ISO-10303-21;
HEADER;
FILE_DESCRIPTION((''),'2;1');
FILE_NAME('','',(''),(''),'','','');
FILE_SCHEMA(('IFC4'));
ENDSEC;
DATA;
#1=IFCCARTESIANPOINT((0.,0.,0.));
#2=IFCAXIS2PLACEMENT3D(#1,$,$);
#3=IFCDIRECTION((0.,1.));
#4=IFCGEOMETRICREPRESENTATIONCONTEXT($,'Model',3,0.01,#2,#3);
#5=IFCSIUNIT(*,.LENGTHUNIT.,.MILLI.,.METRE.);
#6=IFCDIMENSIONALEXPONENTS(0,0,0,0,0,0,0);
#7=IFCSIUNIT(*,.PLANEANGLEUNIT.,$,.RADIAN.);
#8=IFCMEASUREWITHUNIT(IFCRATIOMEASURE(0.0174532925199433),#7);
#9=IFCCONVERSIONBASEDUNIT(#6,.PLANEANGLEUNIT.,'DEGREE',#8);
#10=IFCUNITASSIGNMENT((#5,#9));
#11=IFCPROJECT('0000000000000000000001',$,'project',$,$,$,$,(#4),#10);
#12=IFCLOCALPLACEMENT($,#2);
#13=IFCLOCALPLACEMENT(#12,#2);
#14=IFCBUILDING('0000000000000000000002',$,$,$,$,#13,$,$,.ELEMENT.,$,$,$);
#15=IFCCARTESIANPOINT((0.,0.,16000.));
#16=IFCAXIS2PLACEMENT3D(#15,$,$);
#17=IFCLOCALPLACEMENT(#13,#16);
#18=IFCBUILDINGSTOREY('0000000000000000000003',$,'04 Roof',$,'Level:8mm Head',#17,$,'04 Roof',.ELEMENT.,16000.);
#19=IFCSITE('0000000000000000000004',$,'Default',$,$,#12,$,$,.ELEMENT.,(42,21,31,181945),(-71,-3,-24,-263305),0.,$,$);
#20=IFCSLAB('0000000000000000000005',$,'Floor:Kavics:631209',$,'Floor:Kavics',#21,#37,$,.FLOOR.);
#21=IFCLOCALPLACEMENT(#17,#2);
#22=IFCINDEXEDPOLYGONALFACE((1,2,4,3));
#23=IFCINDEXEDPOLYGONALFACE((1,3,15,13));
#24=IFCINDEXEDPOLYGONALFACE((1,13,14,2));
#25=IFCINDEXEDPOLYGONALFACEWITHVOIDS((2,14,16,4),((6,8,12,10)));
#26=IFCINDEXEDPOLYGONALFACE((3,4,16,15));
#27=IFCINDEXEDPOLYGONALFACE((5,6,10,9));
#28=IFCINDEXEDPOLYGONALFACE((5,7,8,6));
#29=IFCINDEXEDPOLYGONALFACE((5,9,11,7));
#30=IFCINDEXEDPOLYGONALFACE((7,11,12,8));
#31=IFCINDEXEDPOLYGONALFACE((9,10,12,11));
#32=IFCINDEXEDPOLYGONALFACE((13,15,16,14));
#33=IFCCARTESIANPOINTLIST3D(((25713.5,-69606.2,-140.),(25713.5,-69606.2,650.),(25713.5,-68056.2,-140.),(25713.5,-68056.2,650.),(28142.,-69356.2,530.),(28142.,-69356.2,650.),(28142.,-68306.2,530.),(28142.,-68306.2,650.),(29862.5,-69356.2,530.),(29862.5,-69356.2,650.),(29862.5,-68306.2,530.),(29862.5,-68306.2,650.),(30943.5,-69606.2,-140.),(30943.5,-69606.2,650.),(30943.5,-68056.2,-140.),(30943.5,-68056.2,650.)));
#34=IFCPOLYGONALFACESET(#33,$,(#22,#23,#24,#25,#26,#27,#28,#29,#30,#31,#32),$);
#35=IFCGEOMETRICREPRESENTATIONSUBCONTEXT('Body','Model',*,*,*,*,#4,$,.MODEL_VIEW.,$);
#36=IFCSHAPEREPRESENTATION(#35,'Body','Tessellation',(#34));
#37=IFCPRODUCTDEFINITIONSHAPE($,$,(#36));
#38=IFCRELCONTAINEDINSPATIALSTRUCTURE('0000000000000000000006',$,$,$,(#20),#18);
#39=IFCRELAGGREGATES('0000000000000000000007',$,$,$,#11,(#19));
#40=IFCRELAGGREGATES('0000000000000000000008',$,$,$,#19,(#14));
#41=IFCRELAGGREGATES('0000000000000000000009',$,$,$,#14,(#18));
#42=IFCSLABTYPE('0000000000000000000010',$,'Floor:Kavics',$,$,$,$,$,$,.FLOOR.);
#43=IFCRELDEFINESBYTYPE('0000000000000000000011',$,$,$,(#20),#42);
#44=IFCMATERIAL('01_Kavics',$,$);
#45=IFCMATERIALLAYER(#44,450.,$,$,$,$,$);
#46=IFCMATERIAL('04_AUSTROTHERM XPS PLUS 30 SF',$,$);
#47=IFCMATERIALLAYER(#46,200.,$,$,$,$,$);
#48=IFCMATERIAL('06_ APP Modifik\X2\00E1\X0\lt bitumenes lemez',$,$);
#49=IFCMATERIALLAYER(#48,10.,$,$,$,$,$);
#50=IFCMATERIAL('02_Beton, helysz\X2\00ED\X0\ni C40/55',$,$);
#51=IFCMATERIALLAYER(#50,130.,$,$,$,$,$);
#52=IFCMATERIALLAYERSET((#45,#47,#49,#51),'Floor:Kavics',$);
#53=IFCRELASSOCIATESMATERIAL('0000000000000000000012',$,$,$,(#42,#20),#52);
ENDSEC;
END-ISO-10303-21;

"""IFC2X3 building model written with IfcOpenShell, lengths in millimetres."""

from ifc_helpers import new_model, entity, si_unit, converted_unit, direction, frame, frame_2d, origin, place, context, subcontext, project, spatial, polyline, rectangle, extrude, boolean, clip, bounded_halfspace, material, layer, layer_set, layer_usage, type_object, element, save


model = new_model("IFC2X3")

# Units and contexts
model_context = context("Model", 3, precision=0.01, world=origin(), true_north=direction((0.0, 1.0)))
body_context = subcontext(model_context, "Body", "Model", "MODEL_VIEW")
ifc_project = project(units=[si_unit("LENGTHUNIT", "METRE", prefix="MILLI"), converted_unit("PLANEANGLEUNIT", "DEGREE", entity("IfcRatioMeasure", 0.0174532925199433), si_unit("PLANEANGLEUNIT", "RADIAN"), dimensions=[0, 0, 0, 0, 0, 0, 0])], contexts=[model_context])

# Site, building, storey
site_placement = place(None, origin())
site = spatial("IfcSite", under=ifc_project, at=site_placement, Name="Default", CompositionType="ELEMENT", RefLatitude=(42, 21, 31, 181945), RefLongitude=(-71, -3, -24, -263305), RefElevation=0.0)
building_placement = place(site_placement, origin())
building = spatial("IfcBuilding", under=site, at=building_placement, CompositionType="ELEMENT")
storey_placement = place(building_placement, frame((0.0, 0.0, 16000.0)))
storey = spatial("IfcBuildingStorey", under=building, at=storey_placement, Name="04 Roof", ObjectType="Level:8mm Head", LongName="04 Roof", CompositionType="ELEMENT", Elevation=16000.0)

# Slab
ifc_material_1 = material(Name="01_Kavics")
ifc_layer_1 = layer(ifc_material_1, 450.0)
ifc_material_2 = material(Name="04_AUSTROTHERM XPS PLUS 30 SF")
ifc_layer_2 = layer(ifc_material_2, 200.0)
ifc_material_3 = material(Name="06_ APP Modifikált bitumenes lemez")
ifc_layer_3 = layer(ifc_material_3, 10.0)
ifc_material_4 = material(Name="02_Beton, helyszíni C40/55")
ifc_layer_4 = layer(ifc_material_4, 130.0)
ifc_layer_set = layer_set([ifc_layer_1, ifc_layer_2, ifc_layer_3, ifc_layer_4], Name="Floor:Kavics")
ifc_layer_usage = layer_usage(ifc_layer_set, "AXIS3", "POSITIVE", 0.0)
slab_type = type_object("IfcSlabType", Name="Floor:Kavics", PredefinedType="FLOOR", material=ifc_layer_set)
slab_placement = place(storey_placement, origin())
element("IfcSlab", 1, at=slab_placement, inside=storey, type_object=slab_type, material=ifc_layer_usage, Name="Floor:Kavics:631209", ObjectType="Floor:Kavics", PredefinedType="FLOOR", context=body_context, shape_type="CSG", body=[
    boolean("DIFFERENCE", clip(extrude(rectangle(XDim=1550.0, YDim=5230.0, at=frame_2d((0.0, 0.0), x_axis=(1.0, 0.0))), frame((28328.5, -68831.2, 650.0), z_axis=(0.0, 0.0, -1.0), x_axis=(0.0, 1.0, 0.0)), (0.0, 0.0, 1.0), 790.0), bounded_halfspace(frame((29862.5, -68306.2, 530.0), z_axis=(0.0, 0.0, 1.0), x_axis=(0.0, -1.0, 0.0)), False, frame((28328.5, -68831.2, 650.0), z_axis=(0.0, 0.0, -1.0), x_axis=(0.0, 1.0, 0.0)), polyline([(-525.0, 1534.0), (525.0, 1534.0), (525.0, -186.5), (-525.0, -186.5), (-525.0, 1534.0)]))), extrude(rectangle(XDim=1050.0, YDim=1720.4, at=frame_2d((0.0, 0.0), x_axis=(1.0, 0.0))), frame((29002.2, -68831.2, 530.0), z_axis=(0.0, 0.0, 1.0), x_axis=(0.0, 1.0, 0.0)), (0.0, 0.0, 1.0), 120.0)),
])

save(model, "model.ifc")
